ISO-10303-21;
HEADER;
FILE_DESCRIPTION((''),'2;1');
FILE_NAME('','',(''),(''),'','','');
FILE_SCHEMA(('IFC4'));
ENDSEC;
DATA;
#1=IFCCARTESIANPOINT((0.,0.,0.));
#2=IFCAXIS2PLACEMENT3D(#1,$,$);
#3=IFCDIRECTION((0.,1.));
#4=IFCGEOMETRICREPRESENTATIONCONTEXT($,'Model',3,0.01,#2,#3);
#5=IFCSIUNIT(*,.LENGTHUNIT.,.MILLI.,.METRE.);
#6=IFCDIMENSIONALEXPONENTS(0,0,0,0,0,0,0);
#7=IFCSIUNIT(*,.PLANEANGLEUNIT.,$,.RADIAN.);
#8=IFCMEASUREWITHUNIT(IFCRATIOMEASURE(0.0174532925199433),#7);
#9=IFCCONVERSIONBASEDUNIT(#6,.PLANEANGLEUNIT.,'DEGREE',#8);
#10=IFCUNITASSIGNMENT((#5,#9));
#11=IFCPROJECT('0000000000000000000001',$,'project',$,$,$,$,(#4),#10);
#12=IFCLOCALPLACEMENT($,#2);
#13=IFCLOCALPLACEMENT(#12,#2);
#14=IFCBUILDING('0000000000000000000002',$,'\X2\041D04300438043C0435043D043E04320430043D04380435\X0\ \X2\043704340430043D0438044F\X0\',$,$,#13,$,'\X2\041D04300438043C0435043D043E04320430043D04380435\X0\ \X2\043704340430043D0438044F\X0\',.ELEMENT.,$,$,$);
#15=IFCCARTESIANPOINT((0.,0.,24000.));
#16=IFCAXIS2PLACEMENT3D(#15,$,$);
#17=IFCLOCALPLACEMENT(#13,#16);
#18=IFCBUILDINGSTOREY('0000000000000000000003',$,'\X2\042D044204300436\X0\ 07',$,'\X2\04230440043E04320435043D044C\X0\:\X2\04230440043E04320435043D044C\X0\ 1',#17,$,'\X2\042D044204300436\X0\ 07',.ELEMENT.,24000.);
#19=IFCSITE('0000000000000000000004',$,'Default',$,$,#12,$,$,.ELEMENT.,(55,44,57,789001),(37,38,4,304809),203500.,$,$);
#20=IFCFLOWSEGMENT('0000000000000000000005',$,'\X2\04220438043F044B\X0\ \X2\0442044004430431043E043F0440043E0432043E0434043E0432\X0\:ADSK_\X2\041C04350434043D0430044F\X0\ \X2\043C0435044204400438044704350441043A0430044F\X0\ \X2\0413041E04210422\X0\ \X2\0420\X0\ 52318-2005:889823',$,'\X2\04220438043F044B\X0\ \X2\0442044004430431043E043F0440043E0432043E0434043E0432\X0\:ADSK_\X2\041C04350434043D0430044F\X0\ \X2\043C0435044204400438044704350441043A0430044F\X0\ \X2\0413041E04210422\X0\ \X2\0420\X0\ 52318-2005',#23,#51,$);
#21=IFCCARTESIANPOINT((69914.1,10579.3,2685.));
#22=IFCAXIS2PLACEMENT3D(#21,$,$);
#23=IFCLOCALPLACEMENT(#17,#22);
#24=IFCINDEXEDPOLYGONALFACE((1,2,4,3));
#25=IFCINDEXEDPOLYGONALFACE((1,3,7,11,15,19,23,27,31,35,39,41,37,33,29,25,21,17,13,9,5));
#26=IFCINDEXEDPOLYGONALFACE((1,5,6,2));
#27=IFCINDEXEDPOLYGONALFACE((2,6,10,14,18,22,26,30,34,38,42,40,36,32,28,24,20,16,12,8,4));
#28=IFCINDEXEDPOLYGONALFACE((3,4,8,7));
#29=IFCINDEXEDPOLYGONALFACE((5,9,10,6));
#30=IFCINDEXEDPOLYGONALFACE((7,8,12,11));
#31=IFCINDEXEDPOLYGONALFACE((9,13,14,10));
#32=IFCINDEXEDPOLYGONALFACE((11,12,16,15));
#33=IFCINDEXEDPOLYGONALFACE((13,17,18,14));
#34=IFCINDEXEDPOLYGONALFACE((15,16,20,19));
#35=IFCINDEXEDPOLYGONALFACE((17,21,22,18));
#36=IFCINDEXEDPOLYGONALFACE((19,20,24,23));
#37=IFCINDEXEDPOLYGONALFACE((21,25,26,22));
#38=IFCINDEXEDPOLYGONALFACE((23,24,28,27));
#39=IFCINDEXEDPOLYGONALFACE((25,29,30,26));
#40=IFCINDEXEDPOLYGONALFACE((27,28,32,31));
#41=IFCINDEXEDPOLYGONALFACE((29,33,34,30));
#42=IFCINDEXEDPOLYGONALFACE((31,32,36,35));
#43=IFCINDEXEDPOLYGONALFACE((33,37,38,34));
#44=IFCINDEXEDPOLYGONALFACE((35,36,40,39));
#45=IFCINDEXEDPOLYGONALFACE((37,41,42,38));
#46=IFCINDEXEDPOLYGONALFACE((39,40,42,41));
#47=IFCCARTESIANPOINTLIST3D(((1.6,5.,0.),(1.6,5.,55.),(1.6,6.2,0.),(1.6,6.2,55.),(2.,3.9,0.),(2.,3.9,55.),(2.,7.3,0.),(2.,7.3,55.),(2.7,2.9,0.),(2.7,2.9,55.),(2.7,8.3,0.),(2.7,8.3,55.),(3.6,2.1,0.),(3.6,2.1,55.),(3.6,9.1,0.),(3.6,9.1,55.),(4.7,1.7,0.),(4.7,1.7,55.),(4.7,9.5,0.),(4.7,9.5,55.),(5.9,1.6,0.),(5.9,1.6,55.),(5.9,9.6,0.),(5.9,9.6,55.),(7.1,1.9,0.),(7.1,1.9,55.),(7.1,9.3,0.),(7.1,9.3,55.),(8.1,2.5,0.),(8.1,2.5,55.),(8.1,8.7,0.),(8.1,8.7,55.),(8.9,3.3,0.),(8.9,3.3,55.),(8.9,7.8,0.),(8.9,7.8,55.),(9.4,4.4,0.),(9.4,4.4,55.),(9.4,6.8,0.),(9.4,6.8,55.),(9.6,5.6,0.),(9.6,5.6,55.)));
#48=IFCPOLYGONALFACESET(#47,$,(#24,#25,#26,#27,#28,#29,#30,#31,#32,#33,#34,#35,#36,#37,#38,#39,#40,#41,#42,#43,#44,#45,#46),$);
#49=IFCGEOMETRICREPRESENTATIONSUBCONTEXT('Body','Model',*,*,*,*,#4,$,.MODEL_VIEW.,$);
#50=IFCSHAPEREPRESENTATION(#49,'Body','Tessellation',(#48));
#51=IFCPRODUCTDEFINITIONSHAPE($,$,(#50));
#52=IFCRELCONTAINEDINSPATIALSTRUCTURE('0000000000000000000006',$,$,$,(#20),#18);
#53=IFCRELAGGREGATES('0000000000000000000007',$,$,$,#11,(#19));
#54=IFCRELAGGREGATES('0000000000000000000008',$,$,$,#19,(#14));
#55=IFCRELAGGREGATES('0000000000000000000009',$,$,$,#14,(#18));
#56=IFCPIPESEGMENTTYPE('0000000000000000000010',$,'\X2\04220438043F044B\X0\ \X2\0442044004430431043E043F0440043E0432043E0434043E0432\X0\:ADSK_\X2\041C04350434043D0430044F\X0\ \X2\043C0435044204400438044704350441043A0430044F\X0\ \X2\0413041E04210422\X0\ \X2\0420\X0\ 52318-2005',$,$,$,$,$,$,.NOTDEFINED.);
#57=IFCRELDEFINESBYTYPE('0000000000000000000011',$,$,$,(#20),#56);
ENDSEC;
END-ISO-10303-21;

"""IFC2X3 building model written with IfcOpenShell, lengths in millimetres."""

from ifc_helpers import new_model, entity, si_unit, converted_unit, direction, frame, origin, origin_2d_with_axis, place, context, subcontext, project, spatial, circle, extrude, type_object, element, save


model = new_model("IFC2X3")

# Units and contexts
model_context = context("Model", 3, precision=0.01, world=origin(), true_north=direction((0.0, 1.0)))
body_context = subcontext(model_context, "Body", "Model", "MODEL_VIEW")
ifc_project = project(units=[si_unit("LENGTHUNIT", "METRE", prefix="MILLI"), converted_unit("PLANEANGLEUNIT", "DEGREE", entity("IfcRatioMeasure", 0.0174532925199433), si_unit("PLANEANGLEUNIT", "RADIAN"), dimensions=[0, 0, 0, 0, 0, 0, 0])], contexts=[model_context])

# Site, building, storey
site_placement = place(None, frame((0.0, 0.0, 0.0)))
site = spatial("IfcSite", under=ifc_project, at=site_placement, Name="Default", CompositionType="ELEMENT", RefLatitude=(55, 44, 57, 789001), RefLongitude=(37, 38, 4, 304809), RefElevation=203500.0)
building_placement = place(site_placement, origin())
building = spatial("IfcBuilding", under=site, at=building_placement, Name="Наименование здания", LongName="Наименование здания", CompositionType="ELEMENT")
storey_placement = place(building_placement, frame((0.0, 0.0, 24000.0)))
storey = spatial("IfcBuildingStorey", under=building, at=storey_placement, Name="Этаж 07", ObjectType="Уровень:Уровень 1", LongName="Этаж 07", CompositionType="ELEMENT", Elevation=24000.0)

# Flow segment
pipe_segment_type = type_object("IfcPipeSegmentType", Name="Типы трубопроводов:ADSK_Медная метрическая ГОСТ Р 52318-2005", PredefinedType="NOTDEFINED")
flow_segment_1_placement = place(storey_placement, frame((69914.1, 10579.3, 2685.0)))
element("IfcFlowSegment", 1, at=flow_segment_1_placement, inside=storey, type_object=pipe_segment_type, Name="Типы трубопроводов:ADSK_Медная метрическая ГОСТ Р 52318-2005:889823", ObjectType="Типы трубопроводов:ADSK_Медная метрическая ГОСТ Р 52318-2005", context=body_context, shape_type="SweptSolid", body=[
    extrude(circle(Radius=4.0, at=origin_2d_with_axis()), frame((5.6, 5.6, 0.0)), (0.0, 0.0, 1.0), 55.0),
])

save(model, "model.ifc")
